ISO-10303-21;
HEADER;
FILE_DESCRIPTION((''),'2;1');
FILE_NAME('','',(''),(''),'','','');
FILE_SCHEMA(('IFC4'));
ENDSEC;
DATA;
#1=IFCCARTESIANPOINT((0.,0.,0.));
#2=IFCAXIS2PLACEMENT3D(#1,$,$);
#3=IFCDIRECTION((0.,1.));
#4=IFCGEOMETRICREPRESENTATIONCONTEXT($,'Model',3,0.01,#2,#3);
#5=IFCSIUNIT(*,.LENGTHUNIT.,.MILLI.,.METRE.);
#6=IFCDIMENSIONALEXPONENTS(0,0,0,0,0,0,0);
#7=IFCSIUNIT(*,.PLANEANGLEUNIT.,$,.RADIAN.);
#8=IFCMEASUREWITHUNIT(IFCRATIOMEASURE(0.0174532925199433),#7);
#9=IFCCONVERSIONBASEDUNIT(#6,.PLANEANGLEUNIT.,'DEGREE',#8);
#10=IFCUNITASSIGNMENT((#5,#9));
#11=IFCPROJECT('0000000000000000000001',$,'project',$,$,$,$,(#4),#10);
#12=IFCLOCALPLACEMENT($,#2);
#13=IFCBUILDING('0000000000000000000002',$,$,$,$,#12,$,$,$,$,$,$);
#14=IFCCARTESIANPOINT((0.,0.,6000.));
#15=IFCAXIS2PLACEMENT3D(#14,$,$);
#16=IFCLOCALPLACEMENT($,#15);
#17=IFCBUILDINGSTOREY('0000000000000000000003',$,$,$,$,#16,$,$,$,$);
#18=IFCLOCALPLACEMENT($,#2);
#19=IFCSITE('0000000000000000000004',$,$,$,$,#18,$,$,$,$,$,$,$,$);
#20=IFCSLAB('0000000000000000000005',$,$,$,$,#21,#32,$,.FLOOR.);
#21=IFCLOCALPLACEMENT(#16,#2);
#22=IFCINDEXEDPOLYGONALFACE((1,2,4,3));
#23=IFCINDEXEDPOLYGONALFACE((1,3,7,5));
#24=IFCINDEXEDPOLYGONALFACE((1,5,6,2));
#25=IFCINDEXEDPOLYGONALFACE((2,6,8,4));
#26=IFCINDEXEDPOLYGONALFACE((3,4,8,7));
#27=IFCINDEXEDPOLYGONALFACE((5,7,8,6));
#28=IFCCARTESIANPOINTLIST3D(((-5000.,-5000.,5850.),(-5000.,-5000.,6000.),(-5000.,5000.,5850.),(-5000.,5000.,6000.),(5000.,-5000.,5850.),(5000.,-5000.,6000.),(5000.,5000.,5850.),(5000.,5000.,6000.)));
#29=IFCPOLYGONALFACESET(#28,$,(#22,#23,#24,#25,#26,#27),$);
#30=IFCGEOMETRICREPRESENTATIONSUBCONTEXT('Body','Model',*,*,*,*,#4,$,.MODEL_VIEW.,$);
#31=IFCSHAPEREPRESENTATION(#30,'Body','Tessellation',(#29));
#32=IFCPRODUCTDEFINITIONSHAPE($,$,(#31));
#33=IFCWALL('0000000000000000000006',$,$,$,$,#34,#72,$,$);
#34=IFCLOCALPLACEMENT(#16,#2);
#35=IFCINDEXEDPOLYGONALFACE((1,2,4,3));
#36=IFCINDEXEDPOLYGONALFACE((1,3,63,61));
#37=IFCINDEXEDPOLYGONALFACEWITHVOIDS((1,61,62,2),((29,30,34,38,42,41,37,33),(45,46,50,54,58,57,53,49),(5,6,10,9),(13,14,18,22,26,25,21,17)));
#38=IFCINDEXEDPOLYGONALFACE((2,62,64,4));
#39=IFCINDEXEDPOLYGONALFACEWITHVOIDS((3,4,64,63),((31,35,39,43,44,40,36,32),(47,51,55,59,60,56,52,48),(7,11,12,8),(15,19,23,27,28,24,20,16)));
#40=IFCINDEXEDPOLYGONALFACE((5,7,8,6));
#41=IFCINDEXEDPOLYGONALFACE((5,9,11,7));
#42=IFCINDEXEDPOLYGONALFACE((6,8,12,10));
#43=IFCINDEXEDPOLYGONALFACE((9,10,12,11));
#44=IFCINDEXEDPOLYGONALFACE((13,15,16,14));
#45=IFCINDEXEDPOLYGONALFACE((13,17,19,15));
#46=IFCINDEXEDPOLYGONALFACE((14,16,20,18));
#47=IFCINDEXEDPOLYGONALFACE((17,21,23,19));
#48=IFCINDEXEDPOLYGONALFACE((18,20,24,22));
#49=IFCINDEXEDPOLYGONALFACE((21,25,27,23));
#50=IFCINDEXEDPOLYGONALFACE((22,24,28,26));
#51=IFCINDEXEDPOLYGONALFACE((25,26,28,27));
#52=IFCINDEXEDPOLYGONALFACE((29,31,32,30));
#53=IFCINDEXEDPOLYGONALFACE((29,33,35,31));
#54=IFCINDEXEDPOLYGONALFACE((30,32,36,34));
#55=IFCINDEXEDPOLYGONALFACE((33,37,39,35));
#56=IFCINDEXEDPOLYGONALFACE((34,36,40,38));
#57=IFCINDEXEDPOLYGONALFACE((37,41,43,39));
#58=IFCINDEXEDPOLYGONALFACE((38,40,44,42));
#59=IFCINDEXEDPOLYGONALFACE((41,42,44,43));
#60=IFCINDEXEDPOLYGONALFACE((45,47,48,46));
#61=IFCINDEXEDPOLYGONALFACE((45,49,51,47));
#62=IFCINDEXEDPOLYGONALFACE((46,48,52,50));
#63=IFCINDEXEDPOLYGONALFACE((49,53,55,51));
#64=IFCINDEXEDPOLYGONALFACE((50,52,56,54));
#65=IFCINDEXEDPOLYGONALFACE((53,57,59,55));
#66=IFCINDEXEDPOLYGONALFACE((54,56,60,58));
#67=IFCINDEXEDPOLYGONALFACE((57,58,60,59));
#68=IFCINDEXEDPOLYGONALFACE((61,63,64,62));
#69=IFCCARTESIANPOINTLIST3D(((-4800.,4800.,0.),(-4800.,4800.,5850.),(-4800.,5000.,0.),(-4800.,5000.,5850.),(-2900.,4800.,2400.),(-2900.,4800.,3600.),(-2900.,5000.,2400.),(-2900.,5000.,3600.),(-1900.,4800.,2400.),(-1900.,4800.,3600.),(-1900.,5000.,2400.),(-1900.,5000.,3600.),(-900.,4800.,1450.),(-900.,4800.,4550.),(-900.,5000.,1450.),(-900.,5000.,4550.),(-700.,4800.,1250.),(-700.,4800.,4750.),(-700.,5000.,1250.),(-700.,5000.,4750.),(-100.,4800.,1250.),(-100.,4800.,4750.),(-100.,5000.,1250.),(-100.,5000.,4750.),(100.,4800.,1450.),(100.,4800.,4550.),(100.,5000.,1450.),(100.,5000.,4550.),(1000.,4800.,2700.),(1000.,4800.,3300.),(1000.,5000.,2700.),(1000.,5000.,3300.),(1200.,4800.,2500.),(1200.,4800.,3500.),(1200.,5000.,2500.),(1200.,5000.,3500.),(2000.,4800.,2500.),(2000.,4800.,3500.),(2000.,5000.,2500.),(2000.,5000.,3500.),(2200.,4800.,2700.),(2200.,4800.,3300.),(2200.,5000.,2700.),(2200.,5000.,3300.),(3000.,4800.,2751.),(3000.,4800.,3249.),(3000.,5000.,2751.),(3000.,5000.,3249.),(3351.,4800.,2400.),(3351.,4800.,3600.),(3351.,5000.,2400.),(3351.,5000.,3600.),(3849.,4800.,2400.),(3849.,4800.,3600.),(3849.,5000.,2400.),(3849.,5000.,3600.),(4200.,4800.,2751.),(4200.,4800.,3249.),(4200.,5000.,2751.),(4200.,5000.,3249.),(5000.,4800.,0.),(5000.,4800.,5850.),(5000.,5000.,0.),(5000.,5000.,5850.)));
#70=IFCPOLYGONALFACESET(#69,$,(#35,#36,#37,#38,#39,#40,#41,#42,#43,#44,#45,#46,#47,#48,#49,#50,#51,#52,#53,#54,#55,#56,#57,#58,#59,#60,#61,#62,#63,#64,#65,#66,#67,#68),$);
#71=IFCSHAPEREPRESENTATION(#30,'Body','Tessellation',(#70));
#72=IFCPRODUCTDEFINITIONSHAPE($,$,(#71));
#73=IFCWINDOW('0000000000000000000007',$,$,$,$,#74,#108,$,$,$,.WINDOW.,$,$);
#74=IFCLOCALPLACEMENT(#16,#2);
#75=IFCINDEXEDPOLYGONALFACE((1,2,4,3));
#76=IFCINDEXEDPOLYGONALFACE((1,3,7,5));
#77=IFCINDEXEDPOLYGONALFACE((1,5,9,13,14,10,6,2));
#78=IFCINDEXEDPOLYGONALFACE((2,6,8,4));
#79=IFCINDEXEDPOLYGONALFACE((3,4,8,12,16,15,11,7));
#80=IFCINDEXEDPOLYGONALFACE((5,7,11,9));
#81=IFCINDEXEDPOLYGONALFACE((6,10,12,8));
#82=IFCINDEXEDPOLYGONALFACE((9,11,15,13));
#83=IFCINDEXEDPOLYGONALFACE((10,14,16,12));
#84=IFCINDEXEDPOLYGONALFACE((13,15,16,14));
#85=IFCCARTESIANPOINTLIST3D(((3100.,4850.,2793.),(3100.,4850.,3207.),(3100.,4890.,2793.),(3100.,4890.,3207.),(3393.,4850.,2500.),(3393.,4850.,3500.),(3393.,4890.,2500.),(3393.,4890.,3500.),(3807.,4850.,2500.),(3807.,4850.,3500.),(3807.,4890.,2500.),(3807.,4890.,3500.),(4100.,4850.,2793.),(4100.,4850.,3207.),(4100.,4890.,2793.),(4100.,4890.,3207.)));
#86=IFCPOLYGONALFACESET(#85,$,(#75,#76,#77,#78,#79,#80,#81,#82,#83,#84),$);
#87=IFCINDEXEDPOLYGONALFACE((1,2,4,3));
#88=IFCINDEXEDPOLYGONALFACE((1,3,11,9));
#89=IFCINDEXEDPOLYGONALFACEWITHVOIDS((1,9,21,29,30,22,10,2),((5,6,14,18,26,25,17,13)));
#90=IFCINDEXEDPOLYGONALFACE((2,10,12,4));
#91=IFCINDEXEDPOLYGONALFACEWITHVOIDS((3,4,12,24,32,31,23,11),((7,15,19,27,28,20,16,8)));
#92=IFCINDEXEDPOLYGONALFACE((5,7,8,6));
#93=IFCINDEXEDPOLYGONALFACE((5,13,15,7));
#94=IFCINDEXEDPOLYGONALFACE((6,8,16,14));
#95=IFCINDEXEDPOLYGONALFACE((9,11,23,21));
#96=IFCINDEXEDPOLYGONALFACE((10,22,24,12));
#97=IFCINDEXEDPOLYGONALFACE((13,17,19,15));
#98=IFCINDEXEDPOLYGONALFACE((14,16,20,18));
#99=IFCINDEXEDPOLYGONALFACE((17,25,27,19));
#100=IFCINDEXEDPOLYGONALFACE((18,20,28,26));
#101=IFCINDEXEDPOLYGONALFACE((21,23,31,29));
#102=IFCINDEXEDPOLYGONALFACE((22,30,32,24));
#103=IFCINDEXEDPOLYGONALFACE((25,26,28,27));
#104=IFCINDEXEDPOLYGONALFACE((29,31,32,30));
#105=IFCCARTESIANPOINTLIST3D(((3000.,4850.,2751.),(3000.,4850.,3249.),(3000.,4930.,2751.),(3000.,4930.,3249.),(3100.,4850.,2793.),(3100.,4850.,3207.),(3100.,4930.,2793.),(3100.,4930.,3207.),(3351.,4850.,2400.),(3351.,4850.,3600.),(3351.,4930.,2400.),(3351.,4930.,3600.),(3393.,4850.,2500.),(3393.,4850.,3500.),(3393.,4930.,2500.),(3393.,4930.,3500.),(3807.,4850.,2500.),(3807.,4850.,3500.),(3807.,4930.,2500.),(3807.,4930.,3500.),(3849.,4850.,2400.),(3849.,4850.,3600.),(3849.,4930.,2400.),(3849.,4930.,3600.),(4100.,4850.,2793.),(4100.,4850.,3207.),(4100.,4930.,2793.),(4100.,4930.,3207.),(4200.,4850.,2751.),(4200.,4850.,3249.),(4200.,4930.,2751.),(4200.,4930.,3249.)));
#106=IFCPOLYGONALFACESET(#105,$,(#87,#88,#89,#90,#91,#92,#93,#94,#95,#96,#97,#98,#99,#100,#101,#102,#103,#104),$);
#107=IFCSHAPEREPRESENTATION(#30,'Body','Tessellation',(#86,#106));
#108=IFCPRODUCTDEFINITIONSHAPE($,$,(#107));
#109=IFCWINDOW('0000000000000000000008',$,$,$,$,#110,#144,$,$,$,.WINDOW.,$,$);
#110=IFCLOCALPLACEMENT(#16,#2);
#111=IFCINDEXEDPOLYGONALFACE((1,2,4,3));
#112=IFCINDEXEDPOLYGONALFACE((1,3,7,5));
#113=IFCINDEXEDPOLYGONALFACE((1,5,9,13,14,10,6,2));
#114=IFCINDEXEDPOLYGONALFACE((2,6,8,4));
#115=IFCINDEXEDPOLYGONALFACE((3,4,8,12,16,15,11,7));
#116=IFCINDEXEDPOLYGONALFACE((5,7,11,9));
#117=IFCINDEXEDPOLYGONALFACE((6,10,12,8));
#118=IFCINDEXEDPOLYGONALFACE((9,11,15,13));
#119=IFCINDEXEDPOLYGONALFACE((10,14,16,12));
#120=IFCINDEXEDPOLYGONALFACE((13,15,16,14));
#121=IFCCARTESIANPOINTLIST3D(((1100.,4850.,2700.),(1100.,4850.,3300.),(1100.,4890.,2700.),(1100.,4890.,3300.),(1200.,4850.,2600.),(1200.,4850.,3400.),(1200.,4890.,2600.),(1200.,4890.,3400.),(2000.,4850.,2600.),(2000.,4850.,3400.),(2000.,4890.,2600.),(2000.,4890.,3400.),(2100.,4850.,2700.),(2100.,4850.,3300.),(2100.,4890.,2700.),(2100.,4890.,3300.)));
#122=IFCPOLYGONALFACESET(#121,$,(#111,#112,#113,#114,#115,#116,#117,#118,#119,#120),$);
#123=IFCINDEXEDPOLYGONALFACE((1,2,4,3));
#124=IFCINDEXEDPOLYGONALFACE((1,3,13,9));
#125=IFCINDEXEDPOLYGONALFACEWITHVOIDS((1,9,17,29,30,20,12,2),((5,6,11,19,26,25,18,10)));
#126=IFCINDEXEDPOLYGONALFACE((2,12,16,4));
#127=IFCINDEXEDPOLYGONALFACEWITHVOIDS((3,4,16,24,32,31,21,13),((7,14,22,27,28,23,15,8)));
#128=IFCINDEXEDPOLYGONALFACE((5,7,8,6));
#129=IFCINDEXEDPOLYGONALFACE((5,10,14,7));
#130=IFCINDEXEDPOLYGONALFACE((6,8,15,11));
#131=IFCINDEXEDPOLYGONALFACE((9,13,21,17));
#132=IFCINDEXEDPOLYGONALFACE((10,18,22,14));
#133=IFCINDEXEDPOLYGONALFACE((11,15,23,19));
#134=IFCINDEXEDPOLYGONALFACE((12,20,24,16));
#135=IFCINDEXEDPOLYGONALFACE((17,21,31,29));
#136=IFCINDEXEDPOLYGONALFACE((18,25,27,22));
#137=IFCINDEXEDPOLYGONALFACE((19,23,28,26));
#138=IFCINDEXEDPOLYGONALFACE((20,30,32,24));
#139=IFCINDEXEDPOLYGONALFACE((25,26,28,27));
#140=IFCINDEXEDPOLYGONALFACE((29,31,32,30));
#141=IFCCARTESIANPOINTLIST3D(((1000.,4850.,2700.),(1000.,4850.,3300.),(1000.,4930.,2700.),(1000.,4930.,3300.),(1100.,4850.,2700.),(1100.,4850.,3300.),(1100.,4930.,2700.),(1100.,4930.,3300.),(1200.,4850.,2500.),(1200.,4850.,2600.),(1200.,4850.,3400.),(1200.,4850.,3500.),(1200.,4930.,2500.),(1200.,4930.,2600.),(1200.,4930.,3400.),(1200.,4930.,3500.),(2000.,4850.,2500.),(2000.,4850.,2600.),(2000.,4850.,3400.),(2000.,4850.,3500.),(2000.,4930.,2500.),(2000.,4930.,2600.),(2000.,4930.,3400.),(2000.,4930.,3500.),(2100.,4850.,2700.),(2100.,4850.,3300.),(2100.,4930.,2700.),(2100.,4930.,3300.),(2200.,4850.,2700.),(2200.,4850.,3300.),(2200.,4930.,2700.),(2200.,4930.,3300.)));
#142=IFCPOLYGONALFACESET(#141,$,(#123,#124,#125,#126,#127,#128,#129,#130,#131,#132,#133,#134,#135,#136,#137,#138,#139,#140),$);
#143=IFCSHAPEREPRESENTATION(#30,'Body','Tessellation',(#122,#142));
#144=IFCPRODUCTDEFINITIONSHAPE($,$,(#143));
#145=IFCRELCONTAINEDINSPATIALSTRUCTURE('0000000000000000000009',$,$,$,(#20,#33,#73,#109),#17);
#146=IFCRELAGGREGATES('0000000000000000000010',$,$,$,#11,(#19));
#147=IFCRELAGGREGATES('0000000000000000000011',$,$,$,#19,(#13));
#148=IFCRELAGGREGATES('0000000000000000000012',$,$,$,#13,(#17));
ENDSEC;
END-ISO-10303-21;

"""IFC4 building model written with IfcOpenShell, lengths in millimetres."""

from ifc_helpers import new_model, entity, si_unit, converted_unit, direction, frame, origin, origin_2d, place, context, subcontext, project, spatial, polyline, rectangle, outline, extrude, element, save


model = new_model("IFC4")

# Units and contexts
model_context = context("Model", 3, precision=0.01, world=origin(), true_north=direction((0.0, 1.0)))
body_context = subcontext(model_context, "Body", "Model", "MODEL_VIEW")
ifc_project = project(units=[si_unit("LENGTHUNIT", "METRE", prefix="MILLI"), converted_unit("PLANEANGLEUNIT", "DEGREE", entity("IfcRatioMeasure", 0.0174532925199433), si_unit("PLANEANGLEUNIT", "RADIAN"), dimensions=[0, 0, 0, 0, 0, 0, 0])], contexts=[model_context])

# Site, building, storey
site_placement = place(None, origin())
site = spatial("IfcSite", under=ifc_project, at=site_placement)
building_placement = place(None, origin())
building = spatial("IfcBuilding", under=site, at=building_placement)
storey_placement = place(None, frame((0.0, 0.0, 6000.0)))
storey = spatial("IfcBuildingStorey", under=building, at=storey_placement)

# Slab
slab_placement = place(storey_placement, frame((0.0, 0.0, 5850.0)))
element("IfcSlab", 1, at=slab_placement, inside=storey, PredefinedType="FLOOR", context=body_context, shape_type="SweptSolid", body=[
    extrude(rectangle(XDim=10000.0, YDim=10000.0, at=origin_2d()), origin(), (0.0, 0.0, 1.0), 150.0),
])

# Wall, openings
wall_1_placement = place(storey_placement, frame((100.0, 4900.0, 0.0), z_axis=(0.0, 0.0, 1.0), x_axis=(-1.0, 0.0, 0.0)))
wall_1 = element("IfcWall", 2, at=wall_1_placement, inside=storey, context=body_context, shape_type="SweptSolid", body=[
    extrude(rectangle(XDim=9800.0, YDim=200.0, at=origin_2d()), origin(), (0.0, 0.0, 1.0), 5850.0),
])
window_1_placement = place(wall_1_placement, frame((-3500.0, 50.0, 3000.0)))
opening_1_placement = place(window_1_placement, frame((0.0, 50.0, 0.0)))
element("IfcOpeningElement", 3, at=opening_1_placement, cuts=wall_1, context=body_context, shape_type="SweptSolid", body=[
    extrude(outline(polyline([(-600.0, -249.0), (-600.0, 249.0), (-249.0, 600.0), (249.0, 600.0), (600.0, 249.0), (600.0, -249.0), (249.0, -600.0), (-249.0, -600.0), (-600.0, -249.0)])), frame((0.0, 0.0, 0.0), z_axis=(0.0, -1.0, 0.0), x_axis=(1.0, 0.0, 0.0)), (0.0, 0.0, 1.0), 200.0),
])
window_2_placement = place(wall_1_placement, frame((-1500.0, 50.0, 3000.0)))
opening_2_placement = place(window_2_placement, frame((0.0, 50.0, 0.0)))
element("IfcOpeningElement", 4, at=opening_2_placement, cuts=wall_1, context=body_context, shape_type="SweptSolid", body=[
    extrude(outline(polyline([(-600.0, -300.0), (-600.0, 300.0), (-400.0, 500.0), (400.0, 500.0), (600.0, 300.0), (600.0, -300.0), (400.0, -500.0), (-400.0, -500.0), (-600.0, -300.0)])), frame((0.0, 0.0, 0.0), z_axis=(0.0, -1.0, 0.0), x_axis=(1.0, 0.0, 0.0)), (0.0, 0.0, 1.0), 200.0),
])
window_3_placement = place(wall_1_placement, frame((500.0, 50.0, 3000.0)))
opening_3_placement = place(window_3_placement, frame((0.0, 50.0, 0.0)))
element("IfcOpeningElement", 5, at=opening_3_placement, cuts=wall_1, context=body_context, shape_type="SweptSolid", body=[
    extrude(outline(polyline([(-500.0, -1550.0), (-500.0, 1550.0), (-300.0, 1750.0), (300.0, 1750.0), (500.0, 1550.0), (500.0, -1550.0), (300.0, -1750.0), (-300.0, -1750.0), (-500.0, -1550.0)])), frame((0.0, 0.0, 0.0), z_axis=(0.0, -1.0, 0.0), x_axis=(1.0, 0.0, 0.0)), (0.0, 0.0, 1.0), 200.0),
])
window_4_placement = place(wall_1_placement, frame((2500.0, 50.0, 3000.0)))
opening_4_placement = place(window_4_placement, frame((0.0, 50.0, 0.0)))
element("IfcOpeningElement", 6, at=opening_4_placement, cuts=wall_1, context=body_context, shape_type="SweptSolid", body=[
    extrude(outline(polyline([(-500.0, -600.0), (-500.0, 600.0), (-500.0, 600.0), (500.0, 600.0), (500.0, 600.0), (500.0, -600.0), (500.0, -600.0), (-500.0, -600.0), (-500.0, -600.0)])), frame((0.0, 0.0, 0.0), z_axis=(0.0, -1.0, 0.0), x_axis=(1.0, 0.0, 0.0)), (0.0, 0.0, 1.0), 200.0),
])

# Windows
cartesian_point_1 = entity("IfcCartesianPoint", [-500.0, -207.0])
shared_polyline_1 = entity("IfcPolyline", [cartesian_point_1, entity("IfcCartesianPoint", [-500.0, 207.0]), entity("IfcCartesianPoint", [-207.0, 500.0]), entity("IfcCartesianPoint", [207.0, 500.0]), entity("IfcCartesianPoint", [500.0, 207.0]), entity("IfcCartesianPoint", [500.0, -207.0]), entity("IfcCartesianPoint", [207.0, -500.0]), entity("IfcCartesianPoint", [-207.0, -500.0]), cartesian_point_1])
cartesian_point_2 = entity("IfcCartesianPoint", [-600.0, -249.0])
element("IfcWindow", 7, at=window_1_placement, inside=storey, PredefinedType="WINDOW", context=body_context, shape_type="SweptSolid", body=[
    entity("IfcExtrudedAreaSolid", entity("IfcArbitraryClosedProfileDef", "AREA", None, shared_polyline_1), entity("IfcAxis2Placement3D", entity("IfcCartesianPoint", [0.0, 0.0, 0.0]), entity("IfcDirection", [0.0, -1.0, 0.0]), entity("IfcDirection", [1.0, 0.0, 0.0])), entity("IfcDirection", [0.0, 0.0, 1.0]), 40.0),
    entity("IfcExtrudedAreaSolid", entity("IfcArbitraryProfileDefWithVoids", "AREA", None, entity("IfcPolyline", [cartesian_point_2, entity("IfcCartesianPoint", [-600.0, 249.0]), entity("IfcCartesianPoint", [-249.0, 600.0]), entity("IfcCartesianPoint", [249.0, 600.0]), entity("IfcCartesianPoint", [600.0, 249.0]), entity("IfcCartesianPoint", [600.0, -249.0]), entity("IfcCartesianPoint", [249.0, -600.0]), entity("IfcCartesianPoint", [-249.0, -600.0]), cartesian_point_2]), [shared_polyline_1]), entity("IfcAxis2Placement3D", entity("IfcCartesianPoint", [0.0, 0.0, 0.0]), entity("IfcDirection", [0.0, -1.0, 0.0]), entity("IfcDirection", [1.0, 0.0, 0.0])), entity("IfcDirection", [0.0, 0.0, 1.0]), 80.0),
])
cartesian_point_3 = entity("IfcCartesianPoint", [-500.0, -300.0])
shared_polyline_2 = entity("IfcPolyline", [cartesian_point_3, entity("IfcCartesianPoint", [-500.0, 300.0]), entity("IfcCartesianPoint", [-400.0, 400.0]), entity("IfcCartesianPoint", [400.0, 400.0]), entity("IfcCartesianPoint", [500.0, 300.0]), entity("IfcCartesianPoint", [500.0, -300.0]), entity("IfcCartesianPoint", [400.0, -400.0]), entity("IfcCartesianPoint", [-400.0, -400.0]), cartesian_point_3])
cartesian_point_4 = entity("IfcCartesianPoint", [-600.0, -300.0])
element("IfcWindow", 8, at=window_2_placement, inside=storey, PredefinedType="WINDOW", context=body_context, shape_type="SweptSolid", body=[
    entity("IfcExtrudedAreaSolid", entity("IfcArbitraryClosedProfileDef", "AREA", None, shared_polyline_2), entity("IfcAxis2Placement3D", entity("IfcCartesianPoint", [0.0, 0.0, 0.0]), entity("IfcDirection", [0.0, -1.0, 0.0]), entity("IfcDirection", [1.0, 0.0, 0.0])), entity("IfcDirection", [0.0, 0.0, 1.0]), 40.0),
    entity("IfcExtrudedAreaSolid", entity("IfcArbitraryProfileDefWithVoids", "AREA", None, entity("IfcPolyline", [cartesian_point_4, entity("IfcCartesianPoint", [-600.0, 300.0]), entity("IfcCartesianPoint", [-400.0, 500.0]), entity("IfcCartesianPoint", [400.0, 500.0]), entity("IfcCartesianPoint", [600.0, 300.0]), entity("IfcCartesianPoint", [600.0, -300.0]), entity("IfcCartesianPoint", [400.0, -500.0]), entity("IfcCartesianPoint", [-400.0, -500.0]), cartesian_point_4]), [shared_polyline_2]), entity("IfcAxis2Placement3D", entity("IfcCartesianPoint", [0.0, 0.0, 0.0]), entity("IfcDirection", [0.0, -1.0, 0.0]), entity("IfcDirection", [1.0, 0.0, 0.0])), entity("IfcDirection", [0.0, 0.0, 1.0]), 80.0),
])

save(model, "model.ifc")
